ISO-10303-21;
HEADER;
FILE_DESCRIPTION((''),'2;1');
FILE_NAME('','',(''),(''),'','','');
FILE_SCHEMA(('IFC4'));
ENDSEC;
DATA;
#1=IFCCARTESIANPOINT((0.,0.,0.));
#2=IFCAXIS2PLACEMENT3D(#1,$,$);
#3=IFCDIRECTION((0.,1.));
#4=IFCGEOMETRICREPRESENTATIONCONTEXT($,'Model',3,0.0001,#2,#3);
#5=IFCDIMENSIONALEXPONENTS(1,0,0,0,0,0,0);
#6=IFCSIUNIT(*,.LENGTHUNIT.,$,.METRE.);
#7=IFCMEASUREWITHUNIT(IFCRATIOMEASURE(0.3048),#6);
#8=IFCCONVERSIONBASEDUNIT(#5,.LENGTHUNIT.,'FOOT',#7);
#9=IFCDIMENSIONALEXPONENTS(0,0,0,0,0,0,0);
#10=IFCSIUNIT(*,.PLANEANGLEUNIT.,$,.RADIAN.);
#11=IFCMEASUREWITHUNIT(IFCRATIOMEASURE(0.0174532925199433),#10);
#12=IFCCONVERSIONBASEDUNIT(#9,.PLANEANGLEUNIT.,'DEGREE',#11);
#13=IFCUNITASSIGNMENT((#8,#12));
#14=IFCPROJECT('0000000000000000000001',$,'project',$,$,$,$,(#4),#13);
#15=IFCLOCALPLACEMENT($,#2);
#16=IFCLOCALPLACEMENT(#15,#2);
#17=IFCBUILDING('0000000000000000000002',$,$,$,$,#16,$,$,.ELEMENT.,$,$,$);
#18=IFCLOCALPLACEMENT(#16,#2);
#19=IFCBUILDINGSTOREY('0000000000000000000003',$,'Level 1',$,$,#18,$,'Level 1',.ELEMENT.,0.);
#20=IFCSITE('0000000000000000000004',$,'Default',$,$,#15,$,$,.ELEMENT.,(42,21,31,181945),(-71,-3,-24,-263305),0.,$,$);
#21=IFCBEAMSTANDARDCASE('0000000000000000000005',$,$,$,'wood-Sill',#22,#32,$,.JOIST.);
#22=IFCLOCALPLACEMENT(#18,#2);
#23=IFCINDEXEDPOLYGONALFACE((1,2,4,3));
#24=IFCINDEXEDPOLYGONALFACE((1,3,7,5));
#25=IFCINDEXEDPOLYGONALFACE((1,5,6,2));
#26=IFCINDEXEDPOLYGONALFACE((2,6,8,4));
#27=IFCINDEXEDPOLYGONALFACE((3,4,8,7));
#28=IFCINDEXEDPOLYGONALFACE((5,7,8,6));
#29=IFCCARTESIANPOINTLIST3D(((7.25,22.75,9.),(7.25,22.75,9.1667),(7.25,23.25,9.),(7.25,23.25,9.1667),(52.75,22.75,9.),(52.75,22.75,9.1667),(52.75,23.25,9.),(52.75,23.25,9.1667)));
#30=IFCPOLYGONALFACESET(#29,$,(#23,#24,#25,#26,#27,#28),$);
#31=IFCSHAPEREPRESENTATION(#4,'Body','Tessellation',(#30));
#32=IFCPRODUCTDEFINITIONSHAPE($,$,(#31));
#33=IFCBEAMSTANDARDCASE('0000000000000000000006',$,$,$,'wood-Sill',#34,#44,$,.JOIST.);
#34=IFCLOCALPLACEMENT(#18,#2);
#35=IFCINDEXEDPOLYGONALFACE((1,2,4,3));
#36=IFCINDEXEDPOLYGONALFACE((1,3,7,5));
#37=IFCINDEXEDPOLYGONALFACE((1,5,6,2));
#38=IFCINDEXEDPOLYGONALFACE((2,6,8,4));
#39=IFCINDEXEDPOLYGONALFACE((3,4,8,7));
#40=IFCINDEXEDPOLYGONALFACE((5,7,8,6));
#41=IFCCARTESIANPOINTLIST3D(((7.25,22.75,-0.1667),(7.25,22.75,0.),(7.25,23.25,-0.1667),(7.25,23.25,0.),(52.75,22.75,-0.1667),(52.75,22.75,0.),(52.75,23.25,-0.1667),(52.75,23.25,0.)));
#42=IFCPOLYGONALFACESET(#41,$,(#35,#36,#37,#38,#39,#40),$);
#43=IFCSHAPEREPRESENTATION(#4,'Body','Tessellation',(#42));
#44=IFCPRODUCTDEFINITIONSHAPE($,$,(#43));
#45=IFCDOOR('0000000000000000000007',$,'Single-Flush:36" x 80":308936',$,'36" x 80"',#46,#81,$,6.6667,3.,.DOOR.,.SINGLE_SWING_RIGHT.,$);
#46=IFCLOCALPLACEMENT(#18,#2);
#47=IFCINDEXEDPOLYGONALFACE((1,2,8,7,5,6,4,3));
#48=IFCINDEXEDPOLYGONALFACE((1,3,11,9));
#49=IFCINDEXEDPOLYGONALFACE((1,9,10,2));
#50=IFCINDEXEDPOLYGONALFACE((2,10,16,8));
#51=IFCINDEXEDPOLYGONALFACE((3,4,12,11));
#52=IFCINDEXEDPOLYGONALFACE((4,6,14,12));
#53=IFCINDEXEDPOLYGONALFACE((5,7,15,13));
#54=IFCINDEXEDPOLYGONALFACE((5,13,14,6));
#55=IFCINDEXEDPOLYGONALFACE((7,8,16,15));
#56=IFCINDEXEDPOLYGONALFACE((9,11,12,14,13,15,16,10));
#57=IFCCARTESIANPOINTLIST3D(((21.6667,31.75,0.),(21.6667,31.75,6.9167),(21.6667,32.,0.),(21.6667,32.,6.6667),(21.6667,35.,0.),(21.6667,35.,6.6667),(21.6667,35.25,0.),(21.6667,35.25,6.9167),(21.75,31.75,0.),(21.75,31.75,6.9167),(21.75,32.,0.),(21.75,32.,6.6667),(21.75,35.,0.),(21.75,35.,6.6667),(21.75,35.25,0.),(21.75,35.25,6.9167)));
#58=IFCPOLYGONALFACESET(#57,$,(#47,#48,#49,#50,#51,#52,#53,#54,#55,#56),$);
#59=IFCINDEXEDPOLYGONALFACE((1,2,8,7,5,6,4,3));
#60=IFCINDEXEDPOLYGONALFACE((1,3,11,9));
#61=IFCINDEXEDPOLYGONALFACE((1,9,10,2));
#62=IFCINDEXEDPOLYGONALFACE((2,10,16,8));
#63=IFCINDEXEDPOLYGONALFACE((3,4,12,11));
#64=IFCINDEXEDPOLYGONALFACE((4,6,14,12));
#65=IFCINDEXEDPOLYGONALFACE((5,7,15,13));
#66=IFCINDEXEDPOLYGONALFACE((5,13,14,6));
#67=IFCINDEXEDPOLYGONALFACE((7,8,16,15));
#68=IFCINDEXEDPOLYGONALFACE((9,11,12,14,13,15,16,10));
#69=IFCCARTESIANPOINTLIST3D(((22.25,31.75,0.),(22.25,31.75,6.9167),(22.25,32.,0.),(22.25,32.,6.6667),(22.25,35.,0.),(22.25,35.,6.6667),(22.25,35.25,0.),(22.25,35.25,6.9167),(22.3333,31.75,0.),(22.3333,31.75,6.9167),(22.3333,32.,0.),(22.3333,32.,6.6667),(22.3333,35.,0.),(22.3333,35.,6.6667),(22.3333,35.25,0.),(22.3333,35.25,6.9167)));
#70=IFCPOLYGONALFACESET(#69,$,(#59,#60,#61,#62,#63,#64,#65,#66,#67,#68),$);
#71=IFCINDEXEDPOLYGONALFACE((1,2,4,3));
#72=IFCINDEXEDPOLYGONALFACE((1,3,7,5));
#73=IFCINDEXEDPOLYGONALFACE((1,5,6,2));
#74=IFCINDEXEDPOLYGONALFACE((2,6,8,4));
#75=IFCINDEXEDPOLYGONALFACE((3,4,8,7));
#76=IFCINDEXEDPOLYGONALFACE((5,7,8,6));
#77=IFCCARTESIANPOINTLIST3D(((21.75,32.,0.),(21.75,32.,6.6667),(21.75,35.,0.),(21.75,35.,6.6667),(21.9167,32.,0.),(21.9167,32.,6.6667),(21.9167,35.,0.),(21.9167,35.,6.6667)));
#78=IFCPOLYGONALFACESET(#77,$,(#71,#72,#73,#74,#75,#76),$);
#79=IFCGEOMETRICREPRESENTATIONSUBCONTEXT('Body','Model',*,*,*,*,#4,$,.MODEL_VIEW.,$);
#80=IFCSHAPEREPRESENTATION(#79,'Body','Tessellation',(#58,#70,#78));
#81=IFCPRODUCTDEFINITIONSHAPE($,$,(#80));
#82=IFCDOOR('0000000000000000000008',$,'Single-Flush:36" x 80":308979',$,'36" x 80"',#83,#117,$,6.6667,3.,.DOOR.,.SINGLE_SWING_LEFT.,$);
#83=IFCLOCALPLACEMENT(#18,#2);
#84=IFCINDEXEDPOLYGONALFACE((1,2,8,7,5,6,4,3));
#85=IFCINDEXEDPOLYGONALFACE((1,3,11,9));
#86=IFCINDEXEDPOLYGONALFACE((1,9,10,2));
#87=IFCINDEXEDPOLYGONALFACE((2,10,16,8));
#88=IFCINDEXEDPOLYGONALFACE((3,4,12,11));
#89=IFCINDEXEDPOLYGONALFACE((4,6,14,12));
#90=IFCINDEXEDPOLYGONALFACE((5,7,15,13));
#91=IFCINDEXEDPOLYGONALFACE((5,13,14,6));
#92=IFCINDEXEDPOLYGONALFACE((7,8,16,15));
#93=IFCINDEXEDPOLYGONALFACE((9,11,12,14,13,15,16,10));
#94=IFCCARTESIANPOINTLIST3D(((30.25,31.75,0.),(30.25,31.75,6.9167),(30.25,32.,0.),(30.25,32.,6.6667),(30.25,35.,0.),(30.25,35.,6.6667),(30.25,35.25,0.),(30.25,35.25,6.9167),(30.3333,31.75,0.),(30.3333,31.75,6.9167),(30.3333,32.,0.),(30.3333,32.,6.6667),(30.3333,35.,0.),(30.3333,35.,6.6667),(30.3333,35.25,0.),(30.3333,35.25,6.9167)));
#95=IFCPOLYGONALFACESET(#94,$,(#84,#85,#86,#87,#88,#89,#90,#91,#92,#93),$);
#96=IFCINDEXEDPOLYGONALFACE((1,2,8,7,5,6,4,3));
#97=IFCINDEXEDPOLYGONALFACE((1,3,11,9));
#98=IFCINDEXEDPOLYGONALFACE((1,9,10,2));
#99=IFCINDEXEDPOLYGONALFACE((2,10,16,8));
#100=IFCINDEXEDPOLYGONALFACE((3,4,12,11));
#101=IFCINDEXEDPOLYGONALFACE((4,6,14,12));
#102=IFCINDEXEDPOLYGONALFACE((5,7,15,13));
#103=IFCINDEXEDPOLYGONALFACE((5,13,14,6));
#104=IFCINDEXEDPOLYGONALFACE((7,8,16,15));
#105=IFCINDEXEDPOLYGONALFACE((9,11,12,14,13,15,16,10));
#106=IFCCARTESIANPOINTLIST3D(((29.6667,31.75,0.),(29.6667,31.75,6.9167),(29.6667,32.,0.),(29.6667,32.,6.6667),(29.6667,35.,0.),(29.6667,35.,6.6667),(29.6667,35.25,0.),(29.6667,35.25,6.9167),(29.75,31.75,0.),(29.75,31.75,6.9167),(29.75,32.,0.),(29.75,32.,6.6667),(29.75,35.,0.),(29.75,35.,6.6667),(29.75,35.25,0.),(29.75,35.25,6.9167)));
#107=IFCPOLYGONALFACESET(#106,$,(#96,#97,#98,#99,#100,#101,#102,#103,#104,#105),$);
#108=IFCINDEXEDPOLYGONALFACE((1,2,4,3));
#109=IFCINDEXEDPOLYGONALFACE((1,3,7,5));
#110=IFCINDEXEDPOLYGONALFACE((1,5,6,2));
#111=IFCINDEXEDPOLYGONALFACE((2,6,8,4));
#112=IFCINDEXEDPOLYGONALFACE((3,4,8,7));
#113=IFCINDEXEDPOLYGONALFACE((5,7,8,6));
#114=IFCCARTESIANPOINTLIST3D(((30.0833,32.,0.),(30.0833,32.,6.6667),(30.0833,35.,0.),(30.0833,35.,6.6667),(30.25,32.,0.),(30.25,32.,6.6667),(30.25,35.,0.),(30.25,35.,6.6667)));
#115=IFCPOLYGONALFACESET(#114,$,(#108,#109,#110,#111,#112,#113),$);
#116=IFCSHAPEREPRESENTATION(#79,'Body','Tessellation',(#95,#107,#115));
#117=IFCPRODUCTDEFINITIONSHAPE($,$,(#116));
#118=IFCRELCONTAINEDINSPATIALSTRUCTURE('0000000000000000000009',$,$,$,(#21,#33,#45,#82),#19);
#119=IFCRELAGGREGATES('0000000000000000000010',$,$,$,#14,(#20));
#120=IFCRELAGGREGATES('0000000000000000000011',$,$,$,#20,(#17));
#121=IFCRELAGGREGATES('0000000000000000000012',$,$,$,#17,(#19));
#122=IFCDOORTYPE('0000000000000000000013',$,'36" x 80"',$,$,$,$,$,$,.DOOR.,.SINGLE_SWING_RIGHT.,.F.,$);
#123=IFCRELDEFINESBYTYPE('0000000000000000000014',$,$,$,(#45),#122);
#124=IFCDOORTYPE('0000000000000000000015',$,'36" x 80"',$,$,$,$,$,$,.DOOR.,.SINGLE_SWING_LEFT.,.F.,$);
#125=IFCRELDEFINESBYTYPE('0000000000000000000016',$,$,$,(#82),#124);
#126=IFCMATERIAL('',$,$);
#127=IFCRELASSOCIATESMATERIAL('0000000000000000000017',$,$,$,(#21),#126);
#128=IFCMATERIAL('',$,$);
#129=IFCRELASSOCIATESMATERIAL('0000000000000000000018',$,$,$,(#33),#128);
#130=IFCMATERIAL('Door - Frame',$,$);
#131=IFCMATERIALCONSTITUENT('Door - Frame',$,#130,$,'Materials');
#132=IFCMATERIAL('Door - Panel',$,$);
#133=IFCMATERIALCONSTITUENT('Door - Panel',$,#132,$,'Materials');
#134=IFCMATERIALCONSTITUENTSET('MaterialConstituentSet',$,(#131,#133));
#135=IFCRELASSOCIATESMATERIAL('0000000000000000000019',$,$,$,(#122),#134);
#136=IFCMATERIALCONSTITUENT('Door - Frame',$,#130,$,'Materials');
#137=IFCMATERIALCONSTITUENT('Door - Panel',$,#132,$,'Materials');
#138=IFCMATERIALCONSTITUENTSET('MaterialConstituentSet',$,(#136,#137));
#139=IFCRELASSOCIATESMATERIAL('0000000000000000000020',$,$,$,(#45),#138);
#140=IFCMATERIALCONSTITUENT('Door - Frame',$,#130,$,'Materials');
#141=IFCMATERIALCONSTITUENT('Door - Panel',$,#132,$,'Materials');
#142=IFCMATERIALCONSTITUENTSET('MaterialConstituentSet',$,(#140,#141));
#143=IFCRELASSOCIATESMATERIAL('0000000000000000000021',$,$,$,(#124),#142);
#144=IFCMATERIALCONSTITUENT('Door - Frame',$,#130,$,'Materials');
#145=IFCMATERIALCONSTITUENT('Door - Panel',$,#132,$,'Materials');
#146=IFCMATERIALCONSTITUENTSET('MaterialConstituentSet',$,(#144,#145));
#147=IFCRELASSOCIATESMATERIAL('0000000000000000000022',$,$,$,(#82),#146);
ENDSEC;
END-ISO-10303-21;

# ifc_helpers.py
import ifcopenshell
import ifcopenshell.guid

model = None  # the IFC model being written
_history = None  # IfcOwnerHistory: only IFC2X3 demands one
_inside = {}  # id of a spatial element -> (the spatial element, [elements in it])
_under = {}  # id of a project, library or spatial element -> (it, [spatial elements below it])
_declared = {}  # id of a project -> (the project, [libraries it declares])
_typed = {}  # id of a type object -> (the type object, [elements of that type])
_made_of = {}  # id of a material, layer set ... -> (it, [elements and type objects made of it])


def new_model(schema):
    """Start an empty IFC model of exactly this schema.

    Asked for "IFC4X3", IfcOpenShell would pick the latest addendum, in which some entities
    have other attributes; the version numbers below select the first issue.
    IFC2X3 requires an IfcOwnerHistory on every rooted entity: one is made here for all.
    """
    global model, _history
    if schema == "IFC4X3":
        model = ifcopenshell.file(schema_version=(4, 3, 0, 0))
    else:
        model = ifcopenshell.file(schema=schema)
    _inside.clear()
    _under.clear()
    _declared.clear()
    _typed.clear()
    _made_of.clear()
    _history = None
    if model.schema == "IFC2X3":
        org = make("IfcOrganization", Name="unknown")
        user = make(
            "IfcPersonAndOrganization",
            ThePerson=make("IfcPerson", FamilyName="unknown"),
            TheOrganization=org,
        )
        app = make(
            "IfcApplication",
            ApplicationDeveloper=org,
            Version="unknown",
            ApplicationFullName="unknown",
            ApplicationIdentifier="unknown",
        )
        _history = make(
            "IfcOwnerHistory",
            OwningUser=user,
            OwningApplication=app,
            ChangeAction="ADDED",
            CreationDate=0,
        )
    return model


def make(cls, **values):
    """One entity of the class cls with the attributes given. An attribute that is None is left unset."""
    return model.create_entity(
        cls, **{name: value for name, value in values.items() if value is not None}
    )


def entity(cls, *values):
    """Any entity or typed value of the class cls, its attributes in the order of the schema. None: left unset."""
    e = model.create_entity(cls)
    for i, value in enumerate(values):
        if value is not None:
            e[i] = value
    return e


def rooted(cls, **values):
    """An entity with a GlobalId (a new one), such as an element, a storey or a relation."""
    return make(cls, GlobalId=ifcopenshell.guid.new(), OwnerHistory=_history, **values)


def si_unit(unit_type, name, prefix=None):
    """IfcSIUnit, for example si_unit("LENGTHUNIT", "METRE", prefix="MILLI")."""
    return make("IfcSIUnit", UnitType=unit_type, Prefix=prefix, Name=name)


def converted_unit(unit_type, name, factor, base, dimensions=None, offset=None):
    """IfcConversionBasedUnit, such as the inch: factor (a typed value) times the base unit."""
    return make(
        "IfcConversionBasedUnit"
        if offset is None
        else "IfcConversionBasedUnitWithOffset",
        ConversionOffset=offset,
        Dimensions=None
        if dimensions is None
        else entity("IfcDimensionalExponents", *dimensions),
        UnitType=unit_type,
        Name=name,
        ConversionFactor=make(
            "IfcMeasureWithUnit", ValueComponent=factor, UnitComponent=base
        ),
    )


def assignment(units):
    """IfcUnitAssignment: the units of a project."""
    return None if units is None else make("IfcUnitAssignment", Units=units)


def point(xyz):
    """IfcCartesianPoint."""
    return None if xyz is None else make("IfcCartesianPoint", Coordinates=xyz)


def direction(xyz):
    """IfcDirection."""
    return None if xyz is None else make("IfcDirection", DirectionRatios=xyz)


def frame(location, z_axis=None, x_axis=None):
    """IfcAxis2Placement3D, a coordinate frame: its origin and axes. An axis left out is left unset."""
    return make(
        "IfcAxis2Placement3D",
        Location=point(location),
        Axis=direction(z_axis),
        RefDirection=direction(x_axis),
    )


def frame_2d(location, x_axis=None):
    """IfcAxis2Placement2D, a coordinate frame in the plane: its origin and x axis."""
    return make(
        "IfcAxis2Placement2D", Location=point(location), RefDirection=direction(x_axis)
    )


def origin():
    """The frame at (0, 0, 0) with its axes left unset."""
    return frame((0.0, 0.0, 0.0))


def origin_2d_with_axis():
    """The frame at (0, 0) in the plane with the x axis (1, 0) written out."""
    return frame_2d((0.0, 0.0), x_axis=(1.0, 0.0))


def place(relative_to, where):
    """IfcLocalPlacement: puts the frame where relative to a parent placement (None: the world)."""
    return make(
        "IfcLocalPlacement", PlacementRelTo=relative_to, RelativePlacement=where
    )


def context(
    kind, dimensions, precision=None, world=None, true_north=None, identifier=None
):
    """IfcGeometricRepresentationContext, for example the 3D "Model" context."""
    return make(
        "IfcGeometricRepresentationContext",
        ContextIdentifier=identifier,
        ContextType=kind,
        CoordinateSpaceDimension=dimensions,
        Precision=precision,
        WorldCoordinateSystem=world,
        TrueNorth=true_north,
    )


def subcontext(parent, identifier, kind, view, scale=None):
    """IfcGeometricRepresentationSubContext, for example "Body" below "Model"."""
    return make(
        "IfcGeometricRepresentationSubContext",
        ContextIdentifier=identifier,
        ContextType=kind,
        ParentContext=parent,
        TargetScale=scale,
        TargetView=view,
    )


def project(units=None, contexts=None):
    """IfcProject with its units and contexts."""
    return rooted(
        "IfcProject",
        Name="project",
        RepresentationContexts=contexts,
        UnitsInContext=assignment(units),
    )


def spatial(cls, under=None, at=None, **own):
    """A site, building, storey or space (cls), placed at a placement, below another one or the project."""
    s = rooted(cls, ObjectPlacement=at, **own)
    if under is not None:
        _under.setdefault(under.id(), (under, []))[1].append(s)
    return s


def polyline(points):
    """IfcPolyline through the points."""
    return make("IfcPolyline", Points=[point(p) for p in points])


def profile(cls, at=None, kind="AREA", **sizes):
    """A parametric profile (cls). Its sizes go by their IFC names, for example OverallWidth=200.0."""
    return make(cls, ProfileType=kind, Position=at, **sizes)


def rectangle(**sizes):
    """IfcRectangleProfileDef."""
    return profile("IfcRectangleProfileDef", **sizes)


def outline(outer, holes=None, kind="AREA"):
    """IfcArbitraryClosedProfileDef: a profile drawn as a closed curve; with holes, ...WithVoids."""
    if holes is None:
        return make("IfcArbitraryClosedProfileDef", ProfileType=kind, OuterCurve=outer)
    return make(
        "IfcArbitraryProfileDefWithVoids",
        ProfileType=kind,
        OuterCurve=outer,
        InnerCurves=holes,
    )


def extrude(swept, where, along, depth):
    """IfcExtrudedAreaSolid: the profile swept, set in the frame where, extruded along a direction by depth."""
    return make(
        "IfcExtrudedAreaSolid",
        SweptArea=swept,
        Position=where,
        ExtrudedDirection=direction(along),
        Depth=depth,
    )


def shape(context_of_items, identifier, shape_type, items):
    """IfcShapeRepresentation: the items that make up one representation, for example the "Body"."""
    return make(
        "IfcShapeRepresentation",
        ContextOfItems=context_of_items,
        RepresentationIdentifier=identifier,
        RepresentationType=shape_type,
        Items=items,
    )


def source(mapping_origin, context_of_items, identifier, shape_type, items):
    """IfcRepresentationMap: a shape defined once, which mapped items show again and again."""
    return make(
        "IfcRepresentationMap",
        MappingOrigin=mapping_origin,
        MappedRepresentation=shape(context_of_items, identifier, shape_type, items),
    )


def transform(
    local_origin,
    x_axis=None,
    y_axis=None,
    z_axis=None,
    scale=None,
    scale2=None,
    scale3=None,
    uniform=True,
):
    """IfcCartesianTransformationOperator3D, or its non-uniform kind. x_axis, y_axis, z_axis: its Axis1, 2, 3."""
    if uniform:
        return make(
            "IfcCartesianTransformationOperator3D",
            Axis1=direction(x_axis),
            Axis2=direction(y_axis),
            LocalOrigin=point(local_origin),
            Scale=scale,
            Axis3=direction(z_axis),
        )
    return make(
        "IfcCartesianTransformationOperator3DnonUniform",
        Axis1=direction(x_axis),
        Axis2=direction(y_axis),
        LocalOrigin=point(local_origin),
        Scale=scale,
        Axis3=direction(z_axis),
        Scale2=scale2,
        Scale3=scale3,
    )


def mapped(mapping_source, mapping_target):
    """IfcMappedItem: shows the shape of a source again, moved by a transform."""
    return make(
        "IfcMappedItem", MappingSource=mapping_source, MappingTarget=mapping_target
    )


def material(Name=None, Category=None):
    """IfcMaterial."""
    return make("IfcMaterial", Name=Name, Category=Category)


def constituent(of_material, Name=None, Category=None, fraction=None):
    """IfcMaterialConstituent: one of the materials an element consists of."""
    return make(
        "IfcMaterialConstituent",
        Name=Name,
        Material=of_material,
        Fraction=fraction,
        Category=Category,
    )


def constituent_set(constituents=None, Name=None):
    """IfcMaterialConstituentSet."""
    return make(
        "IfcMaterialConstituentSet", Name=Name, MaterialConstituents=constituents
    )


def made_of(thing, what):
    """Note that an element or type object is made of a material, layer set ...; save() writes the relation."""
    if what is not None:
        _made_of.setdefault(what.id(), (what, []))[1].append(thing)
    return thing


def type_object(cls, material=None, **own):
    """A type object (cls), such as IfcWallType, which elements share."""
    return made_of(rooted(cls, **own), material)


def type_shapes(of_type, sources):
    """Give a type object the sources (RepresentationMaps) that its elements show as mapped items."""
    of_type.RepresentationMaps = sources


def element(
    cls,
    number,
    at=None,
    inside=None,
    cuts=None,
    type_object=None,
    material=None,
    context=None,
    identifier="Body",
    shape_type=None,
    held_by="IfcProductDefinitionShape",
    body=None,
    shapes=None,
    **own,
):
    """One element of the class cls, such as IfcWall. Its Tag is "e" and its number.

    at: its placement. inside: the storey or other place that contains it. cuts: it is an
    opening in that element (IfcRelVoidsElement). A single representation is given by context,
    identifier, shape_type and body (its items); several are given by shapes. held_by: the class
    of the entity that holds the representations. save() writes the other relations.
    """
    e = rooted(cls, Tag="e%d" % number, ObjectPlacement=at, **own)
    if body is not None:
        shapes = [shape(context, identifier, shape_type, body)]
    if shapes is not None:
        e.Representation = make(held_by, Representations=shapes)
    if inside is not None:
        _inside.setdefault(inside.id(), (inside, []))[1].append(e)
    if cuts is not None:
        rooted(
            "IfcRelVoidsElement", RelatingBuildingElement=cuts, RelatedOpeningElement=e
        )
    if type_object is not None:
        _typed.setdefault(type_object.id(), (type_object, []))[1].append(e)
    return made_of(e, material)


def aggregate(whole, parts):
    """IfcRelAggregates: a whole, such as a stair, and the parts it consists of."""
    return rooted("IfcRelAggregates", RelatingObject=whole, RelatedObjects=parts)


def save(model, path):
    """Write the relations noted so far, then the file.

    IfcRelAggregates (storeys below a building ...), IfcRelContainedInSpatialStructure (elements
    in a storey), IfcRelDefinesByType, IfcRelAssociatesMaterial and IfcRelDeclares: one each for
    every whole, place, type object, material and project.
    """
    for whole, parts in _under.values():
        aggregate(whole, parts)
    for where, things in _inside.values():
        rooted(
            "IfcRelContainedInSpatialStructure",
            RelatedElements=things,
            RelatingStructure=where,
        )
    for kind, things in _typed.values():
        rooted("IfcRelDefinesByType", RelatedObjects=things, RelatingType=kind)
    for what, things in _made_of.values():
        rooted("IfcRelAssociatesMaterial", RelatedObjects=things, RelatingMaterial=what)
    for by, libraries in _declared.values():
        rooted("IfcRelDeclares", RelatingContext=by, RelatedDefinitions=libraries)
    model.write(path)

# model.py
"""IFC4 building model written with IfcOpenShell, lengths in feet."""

from ifc_helpers import new_model, entity, si_unit, converted_unit, direction, frame, origin, origin_2d_with_axis, place, context, subcontext, project, spatial, polyline, rectangle, outline, extrude, source, transform, mapped, material, constituent, constituent_set, type_object, type_shapes, element, save


model = new_model("IFC4")

# Units and contexts
model_context = context("Model", 3, precision=0.0001, world=origin(), true_north=direction((0.0, 1.0)))
body_context = subcontext(model_context, "Body", "Model", "MODEL_VIEW")
ifc_project = project(units=[converted_unit("LENGTHUNIT", "FOOT", entity("IfcRatioMeasure", 0.3048), si_unit("LENGTHUNIT", "METRE"), dimensions=[1, 0, 0, 0, 0, 0, 0]), converted_unit("PLANEANGLEUNIT", "DEGREE", entity("IfcRatioMeasure", 0.0174532925199433), si_unit("PLANEANGLEUNIT", "RADIAN"), dimensions=[0, 0, 0, 0, 0, 0, 0])], contexts=[model_context])

# Site, building, storey
site_placement = place(None, origin())
site = spatial("IfcSite", under=ifc_project, at=site_placement, Name="Default", CompositionType="ELEMENT", RefLatitude=(42, 21, 31, 181945), RefLongitude=(-71, -3, -24, -263305), RefElevation=0.0)
building_placement = place(site_placement, origin())
building = spatial("IfcBuilding", under=site, at=building_placement, CompositionType="ELEMENT")
storey_placement = place(building_placement, origin())
storey = spatial("IfcBuildingStorey", under=building, at=storey_placement, Name="Level 1", LongName="Level 1", CompositionType="ELEMENT", Elevation=0.0)

# Shared definitions
placement_1 = place(storey_placement, frame((30.0, 45.75, 0.0), z_axis=(0.0, 0.0, 1.0), x_axis=(0.0, -1.0, 0.0)))

# Beams
ifc_material_1 = material(Name="")
beam_1_placement = place(placement_1, frame((22.75, 0.0, 9.0), z_axis=(0.0, 0.0, 1.0), x_axis=(0.0, -1.0, 0.0)))
element("IfcBeamStandardCase", 1, at=beam_1_placement, inside=storey, material=ifc_material_1, ObjectType="wood-Sill", PredefinedType="JOIST", context=model_context, shape_type="SweptSolid", body=[
    extrude(rectangle(XDim=45.5, YDim=0.5), origin(), (0.0, 0.0, 1.0), 0.1667),
])
ifc_material_2 = material(Name="")
beam_2_placement = place(placement_1, frame((22.75, 0.0, -0.1667), z_axis=(0.0, 0.0, 1.0), x_axis=(0.0, -1.0, 0.0)))
element("IfcBeamStandardCase", 2, at=beam_2_placement, inside=storey, material=ifc_material_2, ObjectType="wood-Sill", PredefinedType="JOIST", context=model_context, shape_type="SweptSolid", body=[
    extrude(rectangle(XDim=45.5, YDim=0.5), origin(), (0.0, 0.0, 1.0), 0.1667),
])

# Doors
ifc_material_3 = material(Name="Door - Frame")
ifc_constituent_1 = constituent(ifc_material_3, Name="Door - Frame", Category="Materials")
ifc_material_4 = material(Name="Door - Panel")
ifc_constituent_2 = constituent(ifc_material_4, Name="Door - Panel", Category="Materials")
ifc_constituent_set_1 = constituent_set(constituents=[ifc_constituent_1, ifc_constituent_2], Name="MaterialConstituentSet")
ifc_constituent_3 = constituent(ifc_material_3, Name="Door - Frame", Category="Materials")
ifc_constituent_4 = constituent(ifc_material_4, Name="Door - Panel", Category="Materials")
ifc_constituent_set_2 = constituent_set(constituents=[ifc_constituent_3, ifc_constituent_4], Name="MaterialConstituentSet")
door_type_1 = type_object("IfcDoorType", Name="36\" x 80\"", OperationType="SINGLE_SWING_RIGHT", ParameterTakesPrecedence=False, PredefinedType="DOOR", material=ifc_constituent_set_2)
shared_shape_1 = source(origin(), body_context, "Body", "SweptSolid", [
    extrude(outline(polyline([(-1.75, -3.5208), (1.75, -3.5208), (1.75, 3.3958), (1.5, 3.3958), (1.5, -3.2708), (-1.5, -3.2708), (-1.5, 3.3958), (-1.75, 3.3958), (-1.75, -3.5208)])), frame((1.5, 0.5, 3.3958), z_axis=(0.0, 1.0, 0.0), x_axis=(1.0, 0.0, 0.0)), (0.0, 0.0, 1.0), 0.0833),
    extrude(outline(polyline([(-3.5208, -1.75), (3.3958, -1.75), (3.3958, -1.5), (-3.2708, -1.5), (-3.2708, 1.5), (3.3958, 1.5), (3.3958, 1.75), (-3.5208, 1.75), (-3.5208, -1.75)])), frame((1.5, -0.0833, 3.3958), z_axis=(0.0, 1.0, 0.0), x_axis=(0.0, 0.0, -1.0)), (0.0, 0.0, 1.0), 0.0833),
    extrude(rectangle(XDim=0.1667, YDim=3.0, at=origin_2d_with_axis()), frame((1.5, 0.4167, 0.0), z_axis=(0.0, 0.0, 1.0), x_axis=(0.0, 1.0, 0.0)), (0.0, 0.0, 1.0), 6.6667),
])
type_shapes(door_type_1, [shared_shape_1])
placement_2 = place(storey_placement, frame((22.0, 45.75, 0.0), z_axis=(0.0, 0.0, 1.0), x_axis=(0.0, -1.0, 0.0)))
placement_3 = place(placement_2, frame((13.75, 0.25, 0.0)))
door_1_placement = place(placement_3, frame((0.0, 0.0, 0.0), z_axis=(0.0, 0.0, 1.0), x_axis=(-1.0, 0.0, 0.0)))
element("IfcDoor", 3, at=door_1_placement, inside=storey, type_object=door_type_1, material=ifc_constituent_set_1, Name="Single-Flush:36\" x 80\":308936", ObjectType="36\" x 80\"", OperationType="SINGLE_SWING_RIGHT", OverallHeight=6.6667, OverallWidth=3.0, PredefinedType="DOOR", context=body_context, shape_type="MappedRepresentation", body=[
    mapped(shared_shape_1, transform((0.0, 0.0, 0.0), scale=1.0)),
])
ifc_constituent_5 = constituent(ifc_material_3, Name="Door - Frame", Category="Materials")
ifc_constituent_6 = constituent(ifc_material_4, Name="Door - Panel", Category="Materials")
ifc_constituent_set_3 = constituent_set(constituents=[ifc_constituent_5, ifc_constituent_6], Name="MaterialConstituentSet")
ifc_constituent_7 = constituent(ifc_material_3, Name="Door - Frame", Category="Materials")
ifc_constituent_8 = constituent(ifc_material_4, Name="Door - Panel", Category="Materials")
ifc_constituent_set_4 = constituent_set(constituents=[ifc_constituent_7, ifc_constituent_8], Name="MaterialConstituentSet")
door_type_2 = type_object("IfcDoorType", Name="36\" x 80\"", OperationType="SINGLE_SWING_LEFT", ParameterTakesPrecedence=False, PredefinedType="DOOR", material=ifc_constituent_set_4)
shared_shape_2 = source(origin(), body_context, "Body", "SweptSolid", [
    extrude(outline(polyline([(-1.75, -3.5208), (1.75, -3.5208), (1.75, 3.3958), (1.5, 3.3958), (1.5, -3.2708), (-1.5, -3.2708), (-1.5, 3.3958), (-1.75, 3.3958), (-1.75, -3.5208)])), frame((1.5, 0.5833, 3.3958), z_axis=(0.0, -1.0, 0.0), x_axis=(-1.0, 0.0, 0.0)), (0.0, 0.0, 1.0), 0.0833),
    extrude(outline(polyline([(-3.5208, -1.75), (3.3958, -1.75), (3.3958, -1.5), (-3.2708, -1.5), (-3.2708, 1.5), (3.3958, 1.5), (3.3958, 1.75), (-3.5208, 1.75), (-3.5208, -1.75)])), frame((1.5, 0.0, 3.3958), z_axis=(0.0, -1.0, 0.0), x_axis=(0.0, 0.0, -1.0)), (0.0, 0.0, 1.0), 0.0833),
    extrude(rectangle(XDim=3.0, YDim=0.1667, at=origin_2d_with_axis()), frame((1.5, 0.4167, 0.0)), (0.0, 0.0, 1.0), 6.6667),
])
type_shapes(door_type_2, [shared_shape_2])
placement_4 = place(placement_1, frame((10.75, -0.25, 0.0)))
door_2_placement = place(placement_4, origin())
element("IfcDoor", 4, at=door_2_placement, inside=storey, type_object=door_type_2, material=ifc_constituent_set_3, Name="Single-Flush:36\" x 80\":308979", ObjectType="36\" x 80\"", OperationType="SINGLE_SWING_LEFT", OverallHeight=6.6667, OverallWidth=3.0, PredefinedType="DOOR", context=body_context, shape_type="MappedRepresentation", body=[
    mapped(shared_shape_2, transform((0.0, 0.0, 0.0), scale=1.0)),
])

save(model, "model.ifc")
